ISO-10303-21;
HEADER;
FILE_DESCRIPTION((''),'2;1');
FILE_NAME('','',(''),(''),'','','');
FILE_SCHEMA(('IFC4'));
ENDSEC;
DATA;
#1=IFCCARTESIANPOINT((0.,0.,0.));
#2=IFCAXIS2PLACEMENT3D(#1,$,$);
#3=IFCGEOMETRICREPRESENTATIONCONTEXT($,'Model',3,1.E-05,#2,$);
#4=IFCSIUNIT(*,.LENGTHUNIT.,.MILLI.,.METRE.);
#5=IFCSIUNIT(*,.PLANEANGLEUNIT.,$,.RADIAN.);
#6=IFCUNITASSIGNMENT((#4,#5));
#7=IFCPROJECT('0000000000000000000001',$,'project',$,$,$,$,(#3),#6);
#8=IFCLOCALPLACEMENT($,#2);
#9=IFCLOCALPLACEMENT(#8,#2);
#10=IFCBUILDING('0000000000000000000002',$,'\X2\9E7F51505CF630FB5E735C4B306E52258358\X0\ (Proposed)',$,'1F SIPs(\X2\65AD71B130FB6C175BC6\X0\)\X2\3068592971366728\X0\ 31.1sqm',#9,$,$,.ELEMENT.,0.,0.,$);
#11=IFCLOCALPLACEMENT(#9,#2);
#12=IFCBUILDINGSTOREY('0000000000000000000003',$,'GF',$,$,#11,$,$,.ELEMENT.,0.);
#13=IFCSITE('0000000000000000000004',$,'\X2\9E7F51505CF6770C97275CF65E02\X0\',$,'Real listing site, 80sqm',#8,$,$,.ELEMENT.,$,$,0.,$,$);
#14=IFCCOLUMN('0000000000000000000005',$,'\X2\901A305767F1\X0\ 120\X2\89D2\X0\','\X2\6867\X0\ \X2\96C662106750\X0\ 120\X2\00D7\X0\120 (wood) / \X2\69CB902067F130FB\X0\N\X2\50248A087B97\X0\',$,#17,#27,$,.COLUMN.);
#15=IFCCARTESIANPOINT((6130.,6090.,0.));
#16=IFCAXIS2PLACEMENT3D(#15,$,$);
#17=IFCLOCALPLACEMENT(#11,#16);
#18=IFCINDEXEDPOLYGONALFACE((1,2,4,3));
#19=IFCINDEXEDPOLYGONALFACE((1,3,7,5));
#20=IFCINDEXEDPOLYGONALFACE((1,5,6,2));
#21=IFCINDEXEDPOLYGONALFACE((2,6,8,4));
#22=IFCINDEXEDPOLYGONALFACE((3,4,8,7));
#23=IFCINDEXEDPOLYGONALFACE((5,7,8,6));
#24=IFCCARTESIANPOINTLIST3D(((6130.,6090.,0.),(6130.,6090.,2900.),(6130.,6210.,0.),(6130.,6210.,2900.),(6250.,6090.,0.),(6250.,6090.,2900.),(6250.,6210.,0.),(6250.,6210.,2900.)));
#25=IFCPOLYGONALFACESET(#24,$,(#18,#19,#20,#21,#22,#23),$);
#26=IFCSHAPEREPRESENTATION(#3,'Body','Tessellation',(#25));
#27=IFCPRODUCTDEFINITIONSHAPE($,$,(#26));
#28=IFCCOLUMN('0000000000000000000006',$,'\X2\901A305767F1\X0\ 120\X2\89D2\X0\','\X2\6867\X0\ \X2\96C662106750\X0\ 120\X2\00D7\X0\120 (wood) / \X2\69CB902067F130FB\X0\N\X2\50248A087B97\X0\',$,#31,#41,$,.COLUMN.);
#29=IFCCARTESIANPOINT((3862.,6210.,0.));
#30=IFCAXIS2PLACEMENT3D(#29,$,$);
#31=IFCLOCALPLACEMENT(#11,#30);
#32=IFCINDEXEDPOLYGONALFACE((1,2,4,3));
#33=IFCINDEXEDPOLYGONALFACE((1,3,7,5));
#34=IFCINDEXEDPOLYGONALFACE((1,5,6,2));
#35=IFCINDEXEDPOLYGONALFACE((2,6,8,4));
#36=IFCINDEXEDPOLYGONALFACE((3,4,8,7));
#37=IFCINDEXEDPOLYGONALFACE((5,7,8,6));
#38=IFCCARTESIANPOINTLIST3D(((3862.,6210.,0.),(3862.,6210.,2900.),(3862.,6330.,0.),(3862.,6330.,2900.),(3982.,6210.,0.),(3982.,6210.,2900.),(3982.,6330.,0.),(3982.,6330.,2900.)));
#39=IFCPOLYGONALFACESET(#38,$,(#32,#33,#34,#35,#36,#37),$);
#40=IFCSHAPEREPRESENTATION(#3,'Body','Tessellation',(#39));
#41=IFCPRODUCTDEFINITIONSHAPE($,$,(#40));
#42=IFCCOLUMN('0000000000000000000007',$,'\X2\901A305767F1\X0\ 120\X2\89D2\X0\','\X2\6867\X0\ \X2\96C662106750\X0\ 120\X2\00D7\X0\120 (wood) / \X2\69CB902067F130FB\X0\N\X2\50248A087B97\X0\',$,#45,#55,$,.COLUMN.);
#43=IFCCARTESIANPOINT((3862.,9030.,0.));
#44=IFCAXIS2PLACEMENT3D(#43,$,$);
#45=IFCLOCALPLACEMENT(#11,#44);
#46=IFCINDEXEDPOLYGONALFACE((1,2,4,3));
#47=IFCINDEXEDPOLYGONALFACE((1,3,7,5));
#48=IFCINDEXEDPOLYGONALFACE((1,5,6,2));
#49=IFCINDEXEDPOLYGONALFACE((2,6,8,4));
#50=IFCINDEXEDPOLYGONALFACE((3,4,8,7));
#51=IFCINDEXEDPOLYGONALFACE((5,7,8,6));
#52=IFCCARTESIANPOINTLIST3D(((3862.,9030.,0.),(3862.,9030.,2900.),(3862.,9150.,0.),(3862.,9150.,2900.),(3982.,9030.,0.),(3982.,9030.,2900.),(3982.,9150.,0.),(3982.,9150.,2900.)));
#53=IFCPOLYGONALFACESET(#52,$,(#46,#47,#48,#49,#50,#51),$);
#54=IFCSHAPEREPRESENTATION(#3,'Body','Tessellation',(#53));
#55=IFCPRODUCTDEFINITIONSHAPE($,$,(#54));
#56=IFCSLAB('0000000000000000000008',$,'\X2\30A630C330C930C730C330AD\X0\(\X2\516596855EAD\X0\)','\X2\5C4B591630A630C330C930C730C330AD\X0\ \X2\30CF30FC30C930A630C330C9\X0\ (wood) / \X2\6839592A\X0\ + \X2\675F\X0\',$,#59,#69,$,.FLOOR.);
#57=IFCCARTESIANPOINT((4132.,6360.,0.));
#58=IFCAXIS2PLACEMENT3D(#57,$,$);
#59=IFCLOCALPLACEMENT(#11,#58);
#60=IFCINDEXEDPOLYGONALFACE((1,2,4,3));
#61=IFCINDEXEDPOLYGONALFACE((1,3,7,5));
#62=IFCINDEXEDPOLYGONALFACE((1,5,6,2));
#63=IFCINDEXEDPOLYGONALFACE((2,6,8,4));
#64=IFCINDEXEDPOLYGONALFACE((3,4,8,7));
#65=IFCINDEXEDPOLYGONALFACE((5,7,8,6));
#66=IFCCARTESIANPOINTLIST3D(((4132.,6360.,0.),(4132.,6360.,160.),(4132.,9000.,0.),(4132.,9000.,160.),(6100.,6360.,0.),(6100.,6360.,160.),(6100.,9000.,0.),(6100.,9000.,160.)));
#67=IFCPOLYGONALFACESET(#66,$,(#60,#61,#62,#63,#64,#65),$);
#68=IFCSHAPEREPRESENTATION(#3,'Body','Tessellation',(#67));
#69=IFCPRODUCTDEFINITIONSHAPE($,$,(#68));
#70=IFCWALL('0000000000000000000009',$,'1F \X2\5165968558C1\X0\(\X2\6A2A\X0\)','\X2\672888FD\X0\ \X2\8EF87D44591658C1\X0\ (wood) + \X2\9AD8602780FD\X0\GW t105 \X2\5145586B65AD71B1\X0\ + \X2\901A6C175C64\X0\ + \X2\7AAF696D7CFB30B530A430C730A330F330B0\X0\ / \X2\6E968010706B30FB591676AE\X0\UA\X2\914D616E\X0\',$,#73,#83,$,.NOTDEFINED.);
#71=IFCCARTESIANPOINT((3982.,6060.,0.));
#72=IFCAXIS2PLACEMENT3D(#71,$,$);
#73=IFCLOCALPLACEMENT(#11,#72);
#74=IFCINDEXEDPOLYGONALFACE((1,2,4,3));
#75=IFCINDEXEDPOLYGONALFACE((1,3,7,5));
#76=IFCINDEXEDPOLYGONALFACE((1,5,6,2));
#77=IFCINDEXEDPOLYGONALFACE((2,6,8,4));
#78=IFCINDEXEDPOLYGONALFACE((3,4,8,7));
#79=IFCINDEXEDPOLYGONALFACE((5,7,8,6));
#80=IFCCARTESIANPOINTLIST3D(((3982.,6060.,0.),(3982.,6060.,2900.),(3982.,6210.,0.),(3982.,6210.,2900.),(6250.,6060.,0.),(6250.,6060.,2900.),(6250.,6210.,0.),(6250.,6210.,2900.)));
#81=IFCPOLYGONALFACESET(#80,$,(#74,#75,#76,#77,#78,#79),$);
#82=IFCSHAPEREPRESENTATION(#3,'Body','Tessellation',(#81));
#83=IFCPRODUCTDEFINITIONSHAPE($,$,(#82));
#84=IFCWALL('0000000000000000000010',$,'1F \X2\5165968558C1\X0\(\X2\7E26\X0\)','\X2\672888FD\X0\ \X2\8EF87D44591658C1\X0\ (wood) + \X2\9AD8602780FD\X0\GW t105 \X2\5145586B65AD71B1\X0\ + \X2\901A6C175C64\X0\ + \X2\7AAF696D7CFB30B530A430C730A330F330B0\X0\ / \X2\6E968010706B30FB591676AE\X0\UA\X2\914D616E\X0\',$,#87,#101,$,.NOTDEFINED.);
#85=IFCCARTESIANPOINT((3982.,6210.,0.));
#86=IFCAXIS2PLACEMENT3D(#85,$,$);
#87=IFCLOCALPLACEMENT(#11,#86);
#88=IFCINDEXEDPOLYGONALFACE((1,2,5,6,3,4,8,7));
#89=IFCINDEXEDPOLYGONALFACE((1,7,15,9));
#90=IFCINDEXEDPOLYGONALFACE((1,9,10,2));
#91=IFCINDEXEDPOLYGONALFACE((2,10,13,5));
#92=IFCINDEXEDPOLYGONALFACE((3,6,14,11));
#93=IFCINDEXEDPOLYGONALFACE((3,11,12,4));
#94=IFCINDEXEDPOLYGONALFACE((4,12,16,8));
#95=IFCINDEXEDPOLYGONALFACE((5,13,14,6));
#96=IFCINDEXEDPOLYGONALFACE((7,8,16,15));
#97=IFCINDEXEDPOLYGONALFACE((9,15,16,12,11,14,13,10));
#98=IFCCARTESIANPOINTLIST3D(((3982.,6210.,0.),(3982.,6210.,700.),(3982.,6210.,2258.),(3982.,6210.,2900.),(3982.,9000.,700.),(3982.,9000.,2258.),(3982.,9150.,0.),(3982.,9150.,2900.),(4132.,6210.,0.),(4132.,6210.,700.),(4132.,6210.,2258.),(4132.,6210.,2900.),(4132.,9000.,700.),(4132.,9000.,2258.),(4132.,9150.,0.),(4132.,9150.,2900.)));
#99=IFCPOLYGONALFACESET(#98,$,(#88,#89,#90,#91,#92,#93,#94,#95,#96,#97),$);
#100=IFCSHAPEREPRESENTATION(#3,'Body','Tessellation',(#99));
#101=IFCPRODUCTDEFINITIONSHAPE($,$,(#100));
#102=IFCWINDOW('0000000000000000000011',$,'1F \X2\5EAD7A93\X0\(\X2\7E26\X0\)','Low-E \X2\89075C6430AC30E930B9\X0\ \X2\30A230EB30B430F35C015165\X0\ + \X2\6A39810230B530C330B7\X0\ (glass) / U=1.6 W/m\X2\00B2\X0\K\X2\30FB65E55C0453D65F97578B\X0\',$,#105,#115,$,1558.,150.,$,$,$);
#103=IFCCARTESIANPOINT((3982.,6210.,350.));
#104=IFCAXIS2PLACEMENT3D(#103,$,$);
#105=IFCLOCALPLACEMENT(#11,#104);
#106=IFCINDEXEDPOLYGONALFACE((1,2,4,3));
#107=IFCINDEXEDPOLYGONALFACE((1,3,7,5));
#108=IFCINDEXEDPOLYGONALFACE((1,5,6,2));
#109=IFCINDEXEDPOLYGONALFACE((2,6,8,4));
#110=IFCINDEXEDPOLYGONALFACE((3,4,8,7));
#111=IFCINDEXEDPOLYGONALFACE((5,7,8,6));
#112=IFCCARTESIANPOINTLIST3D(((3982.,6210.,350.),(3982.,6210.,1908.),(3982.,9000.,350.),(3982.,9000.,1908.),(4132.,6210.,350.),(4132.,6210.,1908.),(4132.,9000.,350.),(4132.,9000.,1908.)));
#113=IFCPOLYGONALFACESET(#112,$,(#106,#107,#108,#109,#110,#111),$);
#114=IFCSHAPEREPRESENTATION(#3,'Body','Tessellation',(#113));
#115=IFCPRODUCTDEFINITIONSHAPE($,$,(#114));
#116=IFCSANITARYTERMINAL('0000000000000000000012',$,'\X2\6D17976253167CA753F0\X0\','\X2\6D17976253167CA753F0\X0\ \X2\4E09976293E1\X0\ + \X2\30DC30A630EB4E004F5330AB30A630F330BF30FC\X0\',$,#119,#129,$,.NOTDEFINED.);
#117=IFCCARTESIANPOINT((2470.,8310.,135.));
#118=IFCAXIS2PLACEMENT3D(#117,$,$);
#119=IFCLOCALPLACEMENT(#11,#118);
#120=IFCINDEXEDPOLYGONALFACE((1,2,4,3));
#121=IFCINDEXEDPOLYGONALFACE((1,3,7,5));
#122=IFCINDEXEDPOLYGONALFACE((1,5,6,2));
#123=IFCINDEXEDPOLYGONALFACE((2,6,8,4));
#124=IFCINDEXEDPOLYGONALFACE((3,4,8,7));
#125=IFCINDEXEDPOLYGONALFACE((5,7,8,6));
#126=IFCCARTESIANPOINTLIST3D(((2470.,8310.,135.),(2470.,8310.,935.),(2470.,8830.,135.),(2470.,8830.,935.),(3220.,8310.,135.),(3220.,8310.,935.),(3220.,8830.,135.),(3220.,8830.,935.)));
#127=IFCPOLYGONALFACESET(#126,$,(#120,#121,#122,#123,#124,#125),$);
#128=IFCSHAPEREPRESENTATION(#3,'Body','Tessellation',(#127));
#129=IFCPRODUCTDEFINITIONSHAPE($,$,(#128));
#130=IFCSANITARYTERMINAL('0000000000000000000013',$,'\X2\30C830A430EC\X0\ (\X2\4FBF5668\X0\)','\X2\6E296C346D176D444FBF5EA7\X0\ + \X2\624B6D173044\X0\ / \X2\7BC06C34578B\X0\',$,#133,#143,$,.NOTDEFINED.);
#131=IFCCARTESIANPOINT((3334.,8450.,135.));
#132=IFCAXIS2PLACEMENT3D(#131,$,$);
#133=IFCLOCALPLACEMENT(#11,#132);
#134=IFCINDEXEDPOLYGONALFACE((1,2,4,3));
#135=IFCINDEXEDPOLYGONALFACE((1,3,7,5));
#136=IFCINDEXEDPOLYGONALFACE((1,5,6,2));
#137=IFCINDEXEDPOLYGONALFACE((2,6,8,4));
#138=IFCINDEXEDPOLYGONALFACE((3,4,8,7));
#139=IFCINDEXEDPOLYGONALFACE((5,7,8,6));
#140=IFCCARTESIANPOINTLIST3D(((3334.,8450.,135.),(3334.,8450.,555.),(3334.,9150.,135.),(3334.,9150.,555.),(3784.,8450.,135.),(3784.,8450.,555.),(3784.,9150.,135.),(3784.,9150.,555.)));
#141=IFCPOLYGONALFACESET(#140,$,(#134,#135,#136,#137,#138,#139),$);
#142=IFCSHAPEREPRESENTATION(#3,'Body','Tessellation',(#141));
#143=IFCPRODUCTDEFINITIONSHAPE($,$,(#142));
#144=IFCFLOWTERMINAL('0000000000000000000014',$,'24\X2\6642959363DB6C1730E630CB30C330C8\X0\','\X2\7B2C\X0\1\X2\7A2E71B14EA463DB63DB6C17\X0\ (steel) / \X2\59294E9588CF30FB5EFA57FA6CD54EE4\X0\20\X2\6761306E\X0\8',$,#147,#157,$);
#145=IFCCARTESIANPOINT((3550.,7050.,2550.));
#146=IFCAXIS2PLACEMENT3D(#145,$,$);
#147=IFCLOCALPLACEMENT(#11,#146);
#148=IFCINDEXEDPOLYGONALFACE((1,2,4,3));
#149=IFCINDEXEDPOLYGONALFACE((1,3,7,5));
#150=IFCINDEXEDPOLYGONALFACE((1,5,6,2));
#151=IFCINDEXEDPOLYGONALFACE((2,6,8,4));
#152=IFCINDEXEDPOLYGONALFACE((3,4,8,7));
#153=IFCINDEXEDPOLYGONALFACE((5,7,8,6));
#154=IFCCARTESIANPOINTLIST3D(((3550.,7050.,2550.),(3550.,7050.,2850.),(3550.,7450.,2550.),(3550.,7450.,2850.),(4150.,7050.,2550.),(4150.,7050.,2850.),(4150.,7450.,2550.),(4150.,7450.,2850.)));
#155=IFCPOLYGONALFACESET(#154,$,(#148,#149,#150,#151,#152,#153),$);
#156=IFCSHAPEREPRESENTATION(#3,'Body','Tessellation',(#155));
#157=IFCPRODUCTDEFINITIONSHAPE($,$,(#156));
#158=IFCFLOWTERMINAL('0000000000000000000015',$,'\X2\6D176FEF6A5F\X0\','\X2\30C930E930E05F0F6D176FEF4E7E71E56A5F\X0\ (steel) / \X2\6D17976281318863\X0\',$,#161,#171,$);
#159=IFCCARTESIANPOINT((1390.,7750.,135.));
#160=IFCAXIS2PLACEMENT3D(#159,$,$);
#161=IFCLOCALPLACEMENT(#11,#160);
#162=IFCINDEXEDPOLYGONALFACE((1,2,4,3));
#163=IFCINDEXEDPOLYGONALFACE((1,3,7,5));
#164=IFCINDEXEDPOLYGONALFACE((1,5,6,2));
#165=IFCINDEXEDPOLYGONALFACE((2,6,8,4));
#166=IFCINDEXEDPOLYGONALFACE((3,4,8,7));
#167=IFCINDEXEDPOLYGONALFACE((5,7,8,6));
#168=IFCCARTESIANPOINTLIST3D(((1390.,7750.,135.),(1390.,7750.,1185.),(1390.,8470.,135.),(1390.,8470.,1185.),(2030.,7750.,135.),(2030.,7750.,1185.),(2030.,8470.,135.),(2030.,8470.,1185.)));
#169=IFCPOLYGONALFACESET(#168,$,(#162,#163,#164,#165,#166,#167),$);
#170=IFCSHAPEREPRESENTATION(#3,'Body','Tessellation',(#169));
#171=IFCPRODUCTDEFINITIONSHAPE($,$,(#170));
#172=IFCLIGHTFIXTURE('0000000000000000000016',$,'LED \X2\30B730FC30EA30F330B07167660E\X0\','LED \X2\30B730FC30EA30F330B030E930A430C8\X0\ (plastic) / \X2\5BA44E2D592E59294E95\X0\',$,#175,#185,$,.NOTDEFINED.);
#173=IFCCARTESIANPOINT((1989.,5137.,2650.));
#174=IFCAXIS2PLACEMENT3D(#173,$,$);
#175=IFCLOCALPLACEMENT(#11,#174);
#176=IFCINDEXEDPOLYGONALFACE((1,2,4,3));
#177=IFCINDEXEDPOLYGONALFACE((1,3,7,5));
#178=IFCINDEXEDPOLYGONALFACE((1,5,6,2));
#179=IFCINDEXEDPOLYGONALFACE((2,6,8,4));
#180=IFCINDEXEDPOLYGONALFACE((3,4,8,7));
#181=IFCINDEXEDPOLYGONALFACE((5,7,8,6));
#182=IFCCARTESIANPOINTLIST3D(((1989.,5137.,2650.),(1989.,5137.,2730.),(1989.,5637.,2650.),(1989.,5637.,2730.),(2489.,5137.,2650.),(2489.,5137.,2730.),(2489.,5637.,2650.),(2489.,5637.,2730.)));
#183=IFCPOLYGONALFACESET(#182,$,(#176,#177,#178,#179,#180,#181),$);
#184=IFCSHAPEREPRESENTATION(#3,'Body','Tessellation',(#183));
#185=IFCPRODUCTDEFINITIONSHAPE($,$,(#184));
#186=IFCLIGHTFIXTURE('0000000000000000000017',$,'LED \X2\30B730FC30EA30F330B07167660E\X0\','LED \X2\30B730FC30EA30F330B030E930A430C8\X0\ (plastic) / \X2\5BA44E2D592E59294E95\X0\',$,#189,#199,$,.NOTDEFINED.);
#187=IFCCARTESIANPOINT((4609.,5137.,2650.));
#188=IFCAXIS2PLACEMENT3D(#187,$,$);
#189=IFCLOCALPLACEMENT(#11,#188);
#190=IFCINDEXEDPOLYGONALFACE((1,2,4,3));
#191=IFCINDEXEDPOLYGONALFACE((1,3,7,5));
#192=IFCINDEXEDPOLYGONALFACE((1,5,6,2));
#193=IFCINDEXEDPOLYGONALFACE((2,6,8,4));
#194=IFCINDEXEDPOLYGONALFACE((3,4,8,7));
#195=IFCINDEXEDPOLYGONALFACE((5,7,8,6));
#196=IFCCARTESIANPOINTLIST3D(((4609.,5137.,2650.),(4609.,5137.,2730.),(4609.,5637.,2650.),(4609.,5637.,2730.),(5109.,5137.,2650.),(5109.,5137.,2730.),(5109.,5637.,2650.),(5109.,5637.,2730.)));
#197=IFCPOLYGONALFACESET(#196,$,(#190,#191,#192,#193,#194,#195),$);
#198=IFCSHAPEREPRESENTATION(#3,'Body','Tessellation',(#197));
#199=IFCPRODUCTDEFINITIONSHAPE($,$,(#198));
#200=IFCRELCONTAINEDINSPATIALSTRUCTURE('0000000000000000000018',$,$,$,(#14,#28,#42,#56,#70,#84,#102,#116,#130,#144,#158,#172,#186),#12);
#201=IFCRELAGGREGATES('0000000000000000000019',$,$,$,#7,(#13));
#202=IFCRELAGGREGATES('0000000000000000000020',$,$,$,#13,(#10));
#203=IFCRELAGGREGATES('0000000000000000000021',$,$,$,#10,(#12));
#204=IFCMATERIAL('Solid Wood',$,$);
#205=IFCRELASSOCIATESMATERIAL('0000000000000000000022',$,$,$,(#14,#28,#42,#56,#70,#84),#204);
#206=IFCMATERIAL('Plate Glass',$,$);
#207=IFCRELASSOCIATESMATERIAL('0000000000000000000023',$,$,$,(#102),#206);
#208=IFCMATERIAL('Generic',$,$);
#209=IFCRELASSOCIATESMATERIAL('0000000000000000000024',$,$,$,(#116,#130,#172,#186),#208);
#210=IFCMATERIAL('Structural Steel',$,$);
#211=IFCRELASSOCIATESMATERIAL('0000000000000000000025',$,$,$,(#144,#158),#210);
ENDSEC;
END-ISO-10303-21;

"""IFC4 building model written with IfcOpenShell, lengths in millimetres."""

from ifc_helpers import new_model, si_unit, frame, frame_2d, origin, place, context, project, spatial, rectangle, extrude, material, element, fill, save


model = new_model("IFC4")

# Units and contexts
model_context = context("Model", 3, precision=1e-05, world=origin())
ifc_project = project(units=[si_unit("LENGTHUNIT", "METRE", prefix="MILLI"), si_unit("PLANEANGLEUNIT", "RADIAN")], contexts=[model_context])

# Site, building, storey
site_placement = place(None, origin())
site = spatial("IfcSite", under=ifc_project, at=site_placement, Name="鹿児島県霧島市", ObjectType="Real listing site, 80sqm", CompositionType="ELEMENT", RefElevation=0.0)
building_placement = place(site_placement, origin())
building = spatial("IfcBuilding", under=site, at=building_placement, Name="鹿児島・平屋の別荘 (Proposed)", ObjectType="1F SIPs(断熱・気密)と天然木 31.1sqm", CompositionType="ELEMENT", ElevationOfRefHeight=0.0, ElevationOfTerrain=0.0)
storey_placement = place(building_placement, origin())
storey = spatial("IfcBuildingStorey", under=building, at=storey_placement, Name="GF", CompositionType="ELEMENT", Elevation=0.0)

# Columns
ifc_material_1 = material(Name="Solid Wood")
column_1_placement = place(storey_placement, frame((6130.0, 6090.0, 0.0)))
element("IfcColumn", 1, at=column_1_placement, inside=storey, material=ifc_material_1, Name="通し柱 120角", Description="桧 集成材 120×120 (wood) / 構造柱・N値計算", PredefinedType="COLUMN", context=model_context, shape_type="SweptSolid", body=[
    extrude(rectangle(XDim=120.0, YDim=120.0, at=frame_2d((60.0, 60.0))), frame((6130.0, 6090.0, 0.0)), (0.0, 0.0, 1.0), 2900.0),
])
column_2_placement = place(storey_placement, frame((3862.0, 6210.0, 0.0)))
element("IfcColumn", 2, at=column_2_placement, inside=storey, material=ifc_material_1, Name="通し柱 120角", Description="桧 集成材 120×120 (wood) / 構造柱・N値計算", PredefinedType="COLUMN", context=model_context, shape_type="SweptSolid", body=[
    extrude(rectangle(XDim=120.0, YDim=120.0, at=frame_2d((60.0, 60.0))), frame((3862.0, 6210.0, 0.0)), (0.0, 0.0, 1.0), 2900.0),
])
column_3_placement = place(storey_placement, frame((3862.0, 9030.0, 0.0)))
element("IfcColumn", 3, at=column_3_placement, inside=storey, material=ifc_material_1, Name="通し柱 120角", Description="桧 集成材 120×120 (wood) / 構造柱・N値計算", PredefinedType="COLUMN", context=model_context, shape_type="SweptSolid", body=[
    extrude(rectangle(XDim=120.0, YDim=120.0, at=frame_2d((60.0, 60.0))), frame((3862.0, 9030.0, 0.0)), (0.0, 0.0, 1.0), 2900.0),
])

# Slab
slab_placement = place(storey_placement, frame((4132.0, 6360.0, 0.0)))
element("IfcSlab", 4, at=slab_placement, inside=storey, material=ifc_material_1, Name="ウッドデッキ(入隅庭)", Description="屋外ウッドデッキ ハードウッド (wood) / 根太 + 束", PredefinedType="FLOOR", context=model_context, shape_type="SweptSolid", body=[
    extrude(rectangle(XDim=1968.0, YDim=2640.0, at=frame_2d((984.0, 1320.0))), frame((4132.0, 6360.0, 0.0)), (0.0, 0.0, 1.0), 160.0),
])

# Wall
wall_1_placement = place(storey_placement, frame((3982.0, 6060.0, 0.0)))
element("IfcWall", 5, at=wall_1_placement, inside=storey, material=ifc_material_1, Name="1F 入隅壁(横)", Description="木製 軸組外壁 (wood) + 高性能GW t105 充填断熱 + 通気層 + 窯業系サイディング / 準耐火・外皮UA配慮", PredefinedType="NOTDEFINED", context=model_context, shape_type="SweptSolid", body=[
    extrude(rectangle(XDim=2268.0, YDim=150.0, at=frame_2d((1134.0, 75.0))), frame((3982.0, 6060.0, 0.0)), (0.0, 0.0, 1.0), 2900.0),
])

# Wall, opening, window
wall_2_placement = place(storey_placement, frame((3982.0, 6210.0, 0.0)))
wall_2 = element("IfcWall", 6, at=wall_2_placement, inside=storey, material=ifc_material_1, Name="1F 入隅壁(縦)", Description="木製 軸組外壁 (wood) + 高性能GW t105 充填断熱 + 通気層 + 窯業系サイディング / 準耐火・外皮UA配慮", PredefinedType="NOTDEFINED", context=model_context, shape_type="SweptSolid", body=[
    extrude(rectangle(XDim=150.0, YDim=2940.0, at=frame_2d((75.0, 1470.0))), frame((3982.0, 6210.0, 0.0)), (0.0, 0.0, 1.0), 2900.0),
])
opening_placement = place(storey_placement, frame((3982.0, 6210.0, 350.0)))
opening = element("IfcOpeningElement", 7, at=opening_placement, cuts=wall_2, PredefinedType="NOTDEFINED", context=model_context, shape_type="SweptSolid", body=[
    extrude(rectangle(XDim=150.0, YDim=2790.0, at=frame_2d((75.0, 1395.0))), frame((3982.0, 6210.0, 350.0)), (0.0, 0.0, 1.0), 1558.0),
])
ifc_material_2 = material(Name="Plate Glass")
window_placement = place(storey_placement, frame((3982.0, 6210.0, 350.0)))
window = element("IfcWindow", 8, at=window_placement, inside=storey, material=ifc_material_2, Name="1F 庭窓(縦)", Description="Low-E 複層ガラス アルゴン封入 + 樹脂サッシ (glass) / U=1.6 W/m²K・日射取得型", OverallHeight=1558.0, OverallWidth=150.0, context=model_context, shape_type="SweptSolid", body=[
    extrude(rectangle(XDim=150.0, YDim=2790.0, at=frame_2d((75.0, 1395.0))), frame((3982.0, 6210.0, 350.0)), (0.0, 0.0, 1.0), 1558.0),
])
fill(opening, window)

# Sanitary terminals
ifc_material_3 = material(Name="Generic")
sanitary_terminal_1_placement = place(storey_placement, frame((2470.0, 8310.0, 135.0)))
element("IfcSanitaryTerminal", 9, at=sanitary_terminal_1_placement, inside=storey, material=ifc_material_3, Name="洗面化粧台", Description="洗面化粧台 三面鏡 + ボウル一体カウンター", PredefinedType="NOTDEFINED", context=model_context, shape_type="SweptSolid", body=[
    extrude(rectangle(XDim=750.0, YDim=520.0, at=frame_2d((375.0, 260.0))), frame((2470.0, 8310.0, 135.0)), (0.0, 0.0, 1.0), 800.0),
])
sanitary_terminal_2_placement = place(storey_placement, frame((3334.0, 8450.0, 135.0)))
element("IfcSanitaryTerminal", 10, at=sanitary_terminal_2_placement, inside=storey, material=ifc_material_3, Name="トイレ (便器)", Description="温水洗浄便座 + 手洗い / 節水型", PredefinedType="NOTDEFINED", context=model_context, shape_type="SweptSolid", body=[
    extrude(rectangle(XDim=450.0, YDim=700.0, at=frame_2d((225.0, 350.0))), frame((3334.0, 8450.0, 135.0)), (0.0, 0.0, 1.0), 420.0),
])

# Flow terminals
ifc_material_4 = material(Name="Structural Steel")
flow_terminal_1_placement = place(storey_placement, frame((3550.0, 7050.0, 2550.0)))
element("IfcFlowTerminal", 11, at=flow_terminal_1_placement, inside=storey, material=ifc_material_4, Name="24時間換気ユニット", Description="第1種熱交換換気 (steel) / 天井裏・建基法令20条の8", context=model_context, shape_type="SweptSolid", body=[
    extrude(rectangle(XDim=600.0, YDim=400.0, at=frame_2d((300.0, 200.0))), frame((3550.0, 7050.0, 2550.0)), (0.0, 0.0, 1.0), 300.0),
])
flow_terminal_2_placement = place(storey_placement, frame((1390.0, 7750.0, 135.0)))
element("IfcFlowTerminal", 12, at=flow_terminal_2_placement, inside=storey, material=ifc_material_4, Name="洗濯機", Description="ドラム式洗濯乾燥機 (steel) / 洗面脱衣", context=model_context, shape_type="SweptSolid", body=[
    extrude(rectangle(XDim=640.0, YDim=720.0, at=frame_2d((320.0, 360.0))), frame((1390.0, 7750.0, 135.0)), (0.0, 0.0, 1.0), 1050.0),
])

# Light fixtures
light_fixture_1_placement = place(storey_placement, frame((1989.0, 5137.0, 2650.0)))
element("IfcLightFixture", 13, at=light_fixture_1_placement, inside=storey, material=ifc_material_3, Name="LED シーリング照明", Description="LED シーリングライト (plastic) / 室中央天井", PredefinedType="NOTDEFINED", context=model_context, shape_type="SweptSolid", body=[
    extrude(rectangle(XDim=500.0, YDim=500.0, at=frame_2d((250.0, 250.0))), frame((1989.0, 5137.0, 2650.0)), (0.0, 0.0, 1.0), 80.0),
])
light_fixture_2_placement = place(storey_placement, frame((4609.0, 5137.0, 2650.0)))
element("IfcLightFixture", 14, at=light_fixture_2_placement, inside=storey, material=ifc_material_3, Name="LED シーリング照明", Description="LED シーリングライト (plastic) / 室中央天井", PredefinedType="NOTDEFINED", context=model_context, shape_type="SweptSolid", body=[
    extrude(rectangle(XDim=500.0, YDim=500.0, at=frame_2d((250.0, 250.0))), frame((4609.0, 5137.0, 2650.0)), (0.0, 0.0, 1.0), 80.0),
])

save(model, "model.ifc")
